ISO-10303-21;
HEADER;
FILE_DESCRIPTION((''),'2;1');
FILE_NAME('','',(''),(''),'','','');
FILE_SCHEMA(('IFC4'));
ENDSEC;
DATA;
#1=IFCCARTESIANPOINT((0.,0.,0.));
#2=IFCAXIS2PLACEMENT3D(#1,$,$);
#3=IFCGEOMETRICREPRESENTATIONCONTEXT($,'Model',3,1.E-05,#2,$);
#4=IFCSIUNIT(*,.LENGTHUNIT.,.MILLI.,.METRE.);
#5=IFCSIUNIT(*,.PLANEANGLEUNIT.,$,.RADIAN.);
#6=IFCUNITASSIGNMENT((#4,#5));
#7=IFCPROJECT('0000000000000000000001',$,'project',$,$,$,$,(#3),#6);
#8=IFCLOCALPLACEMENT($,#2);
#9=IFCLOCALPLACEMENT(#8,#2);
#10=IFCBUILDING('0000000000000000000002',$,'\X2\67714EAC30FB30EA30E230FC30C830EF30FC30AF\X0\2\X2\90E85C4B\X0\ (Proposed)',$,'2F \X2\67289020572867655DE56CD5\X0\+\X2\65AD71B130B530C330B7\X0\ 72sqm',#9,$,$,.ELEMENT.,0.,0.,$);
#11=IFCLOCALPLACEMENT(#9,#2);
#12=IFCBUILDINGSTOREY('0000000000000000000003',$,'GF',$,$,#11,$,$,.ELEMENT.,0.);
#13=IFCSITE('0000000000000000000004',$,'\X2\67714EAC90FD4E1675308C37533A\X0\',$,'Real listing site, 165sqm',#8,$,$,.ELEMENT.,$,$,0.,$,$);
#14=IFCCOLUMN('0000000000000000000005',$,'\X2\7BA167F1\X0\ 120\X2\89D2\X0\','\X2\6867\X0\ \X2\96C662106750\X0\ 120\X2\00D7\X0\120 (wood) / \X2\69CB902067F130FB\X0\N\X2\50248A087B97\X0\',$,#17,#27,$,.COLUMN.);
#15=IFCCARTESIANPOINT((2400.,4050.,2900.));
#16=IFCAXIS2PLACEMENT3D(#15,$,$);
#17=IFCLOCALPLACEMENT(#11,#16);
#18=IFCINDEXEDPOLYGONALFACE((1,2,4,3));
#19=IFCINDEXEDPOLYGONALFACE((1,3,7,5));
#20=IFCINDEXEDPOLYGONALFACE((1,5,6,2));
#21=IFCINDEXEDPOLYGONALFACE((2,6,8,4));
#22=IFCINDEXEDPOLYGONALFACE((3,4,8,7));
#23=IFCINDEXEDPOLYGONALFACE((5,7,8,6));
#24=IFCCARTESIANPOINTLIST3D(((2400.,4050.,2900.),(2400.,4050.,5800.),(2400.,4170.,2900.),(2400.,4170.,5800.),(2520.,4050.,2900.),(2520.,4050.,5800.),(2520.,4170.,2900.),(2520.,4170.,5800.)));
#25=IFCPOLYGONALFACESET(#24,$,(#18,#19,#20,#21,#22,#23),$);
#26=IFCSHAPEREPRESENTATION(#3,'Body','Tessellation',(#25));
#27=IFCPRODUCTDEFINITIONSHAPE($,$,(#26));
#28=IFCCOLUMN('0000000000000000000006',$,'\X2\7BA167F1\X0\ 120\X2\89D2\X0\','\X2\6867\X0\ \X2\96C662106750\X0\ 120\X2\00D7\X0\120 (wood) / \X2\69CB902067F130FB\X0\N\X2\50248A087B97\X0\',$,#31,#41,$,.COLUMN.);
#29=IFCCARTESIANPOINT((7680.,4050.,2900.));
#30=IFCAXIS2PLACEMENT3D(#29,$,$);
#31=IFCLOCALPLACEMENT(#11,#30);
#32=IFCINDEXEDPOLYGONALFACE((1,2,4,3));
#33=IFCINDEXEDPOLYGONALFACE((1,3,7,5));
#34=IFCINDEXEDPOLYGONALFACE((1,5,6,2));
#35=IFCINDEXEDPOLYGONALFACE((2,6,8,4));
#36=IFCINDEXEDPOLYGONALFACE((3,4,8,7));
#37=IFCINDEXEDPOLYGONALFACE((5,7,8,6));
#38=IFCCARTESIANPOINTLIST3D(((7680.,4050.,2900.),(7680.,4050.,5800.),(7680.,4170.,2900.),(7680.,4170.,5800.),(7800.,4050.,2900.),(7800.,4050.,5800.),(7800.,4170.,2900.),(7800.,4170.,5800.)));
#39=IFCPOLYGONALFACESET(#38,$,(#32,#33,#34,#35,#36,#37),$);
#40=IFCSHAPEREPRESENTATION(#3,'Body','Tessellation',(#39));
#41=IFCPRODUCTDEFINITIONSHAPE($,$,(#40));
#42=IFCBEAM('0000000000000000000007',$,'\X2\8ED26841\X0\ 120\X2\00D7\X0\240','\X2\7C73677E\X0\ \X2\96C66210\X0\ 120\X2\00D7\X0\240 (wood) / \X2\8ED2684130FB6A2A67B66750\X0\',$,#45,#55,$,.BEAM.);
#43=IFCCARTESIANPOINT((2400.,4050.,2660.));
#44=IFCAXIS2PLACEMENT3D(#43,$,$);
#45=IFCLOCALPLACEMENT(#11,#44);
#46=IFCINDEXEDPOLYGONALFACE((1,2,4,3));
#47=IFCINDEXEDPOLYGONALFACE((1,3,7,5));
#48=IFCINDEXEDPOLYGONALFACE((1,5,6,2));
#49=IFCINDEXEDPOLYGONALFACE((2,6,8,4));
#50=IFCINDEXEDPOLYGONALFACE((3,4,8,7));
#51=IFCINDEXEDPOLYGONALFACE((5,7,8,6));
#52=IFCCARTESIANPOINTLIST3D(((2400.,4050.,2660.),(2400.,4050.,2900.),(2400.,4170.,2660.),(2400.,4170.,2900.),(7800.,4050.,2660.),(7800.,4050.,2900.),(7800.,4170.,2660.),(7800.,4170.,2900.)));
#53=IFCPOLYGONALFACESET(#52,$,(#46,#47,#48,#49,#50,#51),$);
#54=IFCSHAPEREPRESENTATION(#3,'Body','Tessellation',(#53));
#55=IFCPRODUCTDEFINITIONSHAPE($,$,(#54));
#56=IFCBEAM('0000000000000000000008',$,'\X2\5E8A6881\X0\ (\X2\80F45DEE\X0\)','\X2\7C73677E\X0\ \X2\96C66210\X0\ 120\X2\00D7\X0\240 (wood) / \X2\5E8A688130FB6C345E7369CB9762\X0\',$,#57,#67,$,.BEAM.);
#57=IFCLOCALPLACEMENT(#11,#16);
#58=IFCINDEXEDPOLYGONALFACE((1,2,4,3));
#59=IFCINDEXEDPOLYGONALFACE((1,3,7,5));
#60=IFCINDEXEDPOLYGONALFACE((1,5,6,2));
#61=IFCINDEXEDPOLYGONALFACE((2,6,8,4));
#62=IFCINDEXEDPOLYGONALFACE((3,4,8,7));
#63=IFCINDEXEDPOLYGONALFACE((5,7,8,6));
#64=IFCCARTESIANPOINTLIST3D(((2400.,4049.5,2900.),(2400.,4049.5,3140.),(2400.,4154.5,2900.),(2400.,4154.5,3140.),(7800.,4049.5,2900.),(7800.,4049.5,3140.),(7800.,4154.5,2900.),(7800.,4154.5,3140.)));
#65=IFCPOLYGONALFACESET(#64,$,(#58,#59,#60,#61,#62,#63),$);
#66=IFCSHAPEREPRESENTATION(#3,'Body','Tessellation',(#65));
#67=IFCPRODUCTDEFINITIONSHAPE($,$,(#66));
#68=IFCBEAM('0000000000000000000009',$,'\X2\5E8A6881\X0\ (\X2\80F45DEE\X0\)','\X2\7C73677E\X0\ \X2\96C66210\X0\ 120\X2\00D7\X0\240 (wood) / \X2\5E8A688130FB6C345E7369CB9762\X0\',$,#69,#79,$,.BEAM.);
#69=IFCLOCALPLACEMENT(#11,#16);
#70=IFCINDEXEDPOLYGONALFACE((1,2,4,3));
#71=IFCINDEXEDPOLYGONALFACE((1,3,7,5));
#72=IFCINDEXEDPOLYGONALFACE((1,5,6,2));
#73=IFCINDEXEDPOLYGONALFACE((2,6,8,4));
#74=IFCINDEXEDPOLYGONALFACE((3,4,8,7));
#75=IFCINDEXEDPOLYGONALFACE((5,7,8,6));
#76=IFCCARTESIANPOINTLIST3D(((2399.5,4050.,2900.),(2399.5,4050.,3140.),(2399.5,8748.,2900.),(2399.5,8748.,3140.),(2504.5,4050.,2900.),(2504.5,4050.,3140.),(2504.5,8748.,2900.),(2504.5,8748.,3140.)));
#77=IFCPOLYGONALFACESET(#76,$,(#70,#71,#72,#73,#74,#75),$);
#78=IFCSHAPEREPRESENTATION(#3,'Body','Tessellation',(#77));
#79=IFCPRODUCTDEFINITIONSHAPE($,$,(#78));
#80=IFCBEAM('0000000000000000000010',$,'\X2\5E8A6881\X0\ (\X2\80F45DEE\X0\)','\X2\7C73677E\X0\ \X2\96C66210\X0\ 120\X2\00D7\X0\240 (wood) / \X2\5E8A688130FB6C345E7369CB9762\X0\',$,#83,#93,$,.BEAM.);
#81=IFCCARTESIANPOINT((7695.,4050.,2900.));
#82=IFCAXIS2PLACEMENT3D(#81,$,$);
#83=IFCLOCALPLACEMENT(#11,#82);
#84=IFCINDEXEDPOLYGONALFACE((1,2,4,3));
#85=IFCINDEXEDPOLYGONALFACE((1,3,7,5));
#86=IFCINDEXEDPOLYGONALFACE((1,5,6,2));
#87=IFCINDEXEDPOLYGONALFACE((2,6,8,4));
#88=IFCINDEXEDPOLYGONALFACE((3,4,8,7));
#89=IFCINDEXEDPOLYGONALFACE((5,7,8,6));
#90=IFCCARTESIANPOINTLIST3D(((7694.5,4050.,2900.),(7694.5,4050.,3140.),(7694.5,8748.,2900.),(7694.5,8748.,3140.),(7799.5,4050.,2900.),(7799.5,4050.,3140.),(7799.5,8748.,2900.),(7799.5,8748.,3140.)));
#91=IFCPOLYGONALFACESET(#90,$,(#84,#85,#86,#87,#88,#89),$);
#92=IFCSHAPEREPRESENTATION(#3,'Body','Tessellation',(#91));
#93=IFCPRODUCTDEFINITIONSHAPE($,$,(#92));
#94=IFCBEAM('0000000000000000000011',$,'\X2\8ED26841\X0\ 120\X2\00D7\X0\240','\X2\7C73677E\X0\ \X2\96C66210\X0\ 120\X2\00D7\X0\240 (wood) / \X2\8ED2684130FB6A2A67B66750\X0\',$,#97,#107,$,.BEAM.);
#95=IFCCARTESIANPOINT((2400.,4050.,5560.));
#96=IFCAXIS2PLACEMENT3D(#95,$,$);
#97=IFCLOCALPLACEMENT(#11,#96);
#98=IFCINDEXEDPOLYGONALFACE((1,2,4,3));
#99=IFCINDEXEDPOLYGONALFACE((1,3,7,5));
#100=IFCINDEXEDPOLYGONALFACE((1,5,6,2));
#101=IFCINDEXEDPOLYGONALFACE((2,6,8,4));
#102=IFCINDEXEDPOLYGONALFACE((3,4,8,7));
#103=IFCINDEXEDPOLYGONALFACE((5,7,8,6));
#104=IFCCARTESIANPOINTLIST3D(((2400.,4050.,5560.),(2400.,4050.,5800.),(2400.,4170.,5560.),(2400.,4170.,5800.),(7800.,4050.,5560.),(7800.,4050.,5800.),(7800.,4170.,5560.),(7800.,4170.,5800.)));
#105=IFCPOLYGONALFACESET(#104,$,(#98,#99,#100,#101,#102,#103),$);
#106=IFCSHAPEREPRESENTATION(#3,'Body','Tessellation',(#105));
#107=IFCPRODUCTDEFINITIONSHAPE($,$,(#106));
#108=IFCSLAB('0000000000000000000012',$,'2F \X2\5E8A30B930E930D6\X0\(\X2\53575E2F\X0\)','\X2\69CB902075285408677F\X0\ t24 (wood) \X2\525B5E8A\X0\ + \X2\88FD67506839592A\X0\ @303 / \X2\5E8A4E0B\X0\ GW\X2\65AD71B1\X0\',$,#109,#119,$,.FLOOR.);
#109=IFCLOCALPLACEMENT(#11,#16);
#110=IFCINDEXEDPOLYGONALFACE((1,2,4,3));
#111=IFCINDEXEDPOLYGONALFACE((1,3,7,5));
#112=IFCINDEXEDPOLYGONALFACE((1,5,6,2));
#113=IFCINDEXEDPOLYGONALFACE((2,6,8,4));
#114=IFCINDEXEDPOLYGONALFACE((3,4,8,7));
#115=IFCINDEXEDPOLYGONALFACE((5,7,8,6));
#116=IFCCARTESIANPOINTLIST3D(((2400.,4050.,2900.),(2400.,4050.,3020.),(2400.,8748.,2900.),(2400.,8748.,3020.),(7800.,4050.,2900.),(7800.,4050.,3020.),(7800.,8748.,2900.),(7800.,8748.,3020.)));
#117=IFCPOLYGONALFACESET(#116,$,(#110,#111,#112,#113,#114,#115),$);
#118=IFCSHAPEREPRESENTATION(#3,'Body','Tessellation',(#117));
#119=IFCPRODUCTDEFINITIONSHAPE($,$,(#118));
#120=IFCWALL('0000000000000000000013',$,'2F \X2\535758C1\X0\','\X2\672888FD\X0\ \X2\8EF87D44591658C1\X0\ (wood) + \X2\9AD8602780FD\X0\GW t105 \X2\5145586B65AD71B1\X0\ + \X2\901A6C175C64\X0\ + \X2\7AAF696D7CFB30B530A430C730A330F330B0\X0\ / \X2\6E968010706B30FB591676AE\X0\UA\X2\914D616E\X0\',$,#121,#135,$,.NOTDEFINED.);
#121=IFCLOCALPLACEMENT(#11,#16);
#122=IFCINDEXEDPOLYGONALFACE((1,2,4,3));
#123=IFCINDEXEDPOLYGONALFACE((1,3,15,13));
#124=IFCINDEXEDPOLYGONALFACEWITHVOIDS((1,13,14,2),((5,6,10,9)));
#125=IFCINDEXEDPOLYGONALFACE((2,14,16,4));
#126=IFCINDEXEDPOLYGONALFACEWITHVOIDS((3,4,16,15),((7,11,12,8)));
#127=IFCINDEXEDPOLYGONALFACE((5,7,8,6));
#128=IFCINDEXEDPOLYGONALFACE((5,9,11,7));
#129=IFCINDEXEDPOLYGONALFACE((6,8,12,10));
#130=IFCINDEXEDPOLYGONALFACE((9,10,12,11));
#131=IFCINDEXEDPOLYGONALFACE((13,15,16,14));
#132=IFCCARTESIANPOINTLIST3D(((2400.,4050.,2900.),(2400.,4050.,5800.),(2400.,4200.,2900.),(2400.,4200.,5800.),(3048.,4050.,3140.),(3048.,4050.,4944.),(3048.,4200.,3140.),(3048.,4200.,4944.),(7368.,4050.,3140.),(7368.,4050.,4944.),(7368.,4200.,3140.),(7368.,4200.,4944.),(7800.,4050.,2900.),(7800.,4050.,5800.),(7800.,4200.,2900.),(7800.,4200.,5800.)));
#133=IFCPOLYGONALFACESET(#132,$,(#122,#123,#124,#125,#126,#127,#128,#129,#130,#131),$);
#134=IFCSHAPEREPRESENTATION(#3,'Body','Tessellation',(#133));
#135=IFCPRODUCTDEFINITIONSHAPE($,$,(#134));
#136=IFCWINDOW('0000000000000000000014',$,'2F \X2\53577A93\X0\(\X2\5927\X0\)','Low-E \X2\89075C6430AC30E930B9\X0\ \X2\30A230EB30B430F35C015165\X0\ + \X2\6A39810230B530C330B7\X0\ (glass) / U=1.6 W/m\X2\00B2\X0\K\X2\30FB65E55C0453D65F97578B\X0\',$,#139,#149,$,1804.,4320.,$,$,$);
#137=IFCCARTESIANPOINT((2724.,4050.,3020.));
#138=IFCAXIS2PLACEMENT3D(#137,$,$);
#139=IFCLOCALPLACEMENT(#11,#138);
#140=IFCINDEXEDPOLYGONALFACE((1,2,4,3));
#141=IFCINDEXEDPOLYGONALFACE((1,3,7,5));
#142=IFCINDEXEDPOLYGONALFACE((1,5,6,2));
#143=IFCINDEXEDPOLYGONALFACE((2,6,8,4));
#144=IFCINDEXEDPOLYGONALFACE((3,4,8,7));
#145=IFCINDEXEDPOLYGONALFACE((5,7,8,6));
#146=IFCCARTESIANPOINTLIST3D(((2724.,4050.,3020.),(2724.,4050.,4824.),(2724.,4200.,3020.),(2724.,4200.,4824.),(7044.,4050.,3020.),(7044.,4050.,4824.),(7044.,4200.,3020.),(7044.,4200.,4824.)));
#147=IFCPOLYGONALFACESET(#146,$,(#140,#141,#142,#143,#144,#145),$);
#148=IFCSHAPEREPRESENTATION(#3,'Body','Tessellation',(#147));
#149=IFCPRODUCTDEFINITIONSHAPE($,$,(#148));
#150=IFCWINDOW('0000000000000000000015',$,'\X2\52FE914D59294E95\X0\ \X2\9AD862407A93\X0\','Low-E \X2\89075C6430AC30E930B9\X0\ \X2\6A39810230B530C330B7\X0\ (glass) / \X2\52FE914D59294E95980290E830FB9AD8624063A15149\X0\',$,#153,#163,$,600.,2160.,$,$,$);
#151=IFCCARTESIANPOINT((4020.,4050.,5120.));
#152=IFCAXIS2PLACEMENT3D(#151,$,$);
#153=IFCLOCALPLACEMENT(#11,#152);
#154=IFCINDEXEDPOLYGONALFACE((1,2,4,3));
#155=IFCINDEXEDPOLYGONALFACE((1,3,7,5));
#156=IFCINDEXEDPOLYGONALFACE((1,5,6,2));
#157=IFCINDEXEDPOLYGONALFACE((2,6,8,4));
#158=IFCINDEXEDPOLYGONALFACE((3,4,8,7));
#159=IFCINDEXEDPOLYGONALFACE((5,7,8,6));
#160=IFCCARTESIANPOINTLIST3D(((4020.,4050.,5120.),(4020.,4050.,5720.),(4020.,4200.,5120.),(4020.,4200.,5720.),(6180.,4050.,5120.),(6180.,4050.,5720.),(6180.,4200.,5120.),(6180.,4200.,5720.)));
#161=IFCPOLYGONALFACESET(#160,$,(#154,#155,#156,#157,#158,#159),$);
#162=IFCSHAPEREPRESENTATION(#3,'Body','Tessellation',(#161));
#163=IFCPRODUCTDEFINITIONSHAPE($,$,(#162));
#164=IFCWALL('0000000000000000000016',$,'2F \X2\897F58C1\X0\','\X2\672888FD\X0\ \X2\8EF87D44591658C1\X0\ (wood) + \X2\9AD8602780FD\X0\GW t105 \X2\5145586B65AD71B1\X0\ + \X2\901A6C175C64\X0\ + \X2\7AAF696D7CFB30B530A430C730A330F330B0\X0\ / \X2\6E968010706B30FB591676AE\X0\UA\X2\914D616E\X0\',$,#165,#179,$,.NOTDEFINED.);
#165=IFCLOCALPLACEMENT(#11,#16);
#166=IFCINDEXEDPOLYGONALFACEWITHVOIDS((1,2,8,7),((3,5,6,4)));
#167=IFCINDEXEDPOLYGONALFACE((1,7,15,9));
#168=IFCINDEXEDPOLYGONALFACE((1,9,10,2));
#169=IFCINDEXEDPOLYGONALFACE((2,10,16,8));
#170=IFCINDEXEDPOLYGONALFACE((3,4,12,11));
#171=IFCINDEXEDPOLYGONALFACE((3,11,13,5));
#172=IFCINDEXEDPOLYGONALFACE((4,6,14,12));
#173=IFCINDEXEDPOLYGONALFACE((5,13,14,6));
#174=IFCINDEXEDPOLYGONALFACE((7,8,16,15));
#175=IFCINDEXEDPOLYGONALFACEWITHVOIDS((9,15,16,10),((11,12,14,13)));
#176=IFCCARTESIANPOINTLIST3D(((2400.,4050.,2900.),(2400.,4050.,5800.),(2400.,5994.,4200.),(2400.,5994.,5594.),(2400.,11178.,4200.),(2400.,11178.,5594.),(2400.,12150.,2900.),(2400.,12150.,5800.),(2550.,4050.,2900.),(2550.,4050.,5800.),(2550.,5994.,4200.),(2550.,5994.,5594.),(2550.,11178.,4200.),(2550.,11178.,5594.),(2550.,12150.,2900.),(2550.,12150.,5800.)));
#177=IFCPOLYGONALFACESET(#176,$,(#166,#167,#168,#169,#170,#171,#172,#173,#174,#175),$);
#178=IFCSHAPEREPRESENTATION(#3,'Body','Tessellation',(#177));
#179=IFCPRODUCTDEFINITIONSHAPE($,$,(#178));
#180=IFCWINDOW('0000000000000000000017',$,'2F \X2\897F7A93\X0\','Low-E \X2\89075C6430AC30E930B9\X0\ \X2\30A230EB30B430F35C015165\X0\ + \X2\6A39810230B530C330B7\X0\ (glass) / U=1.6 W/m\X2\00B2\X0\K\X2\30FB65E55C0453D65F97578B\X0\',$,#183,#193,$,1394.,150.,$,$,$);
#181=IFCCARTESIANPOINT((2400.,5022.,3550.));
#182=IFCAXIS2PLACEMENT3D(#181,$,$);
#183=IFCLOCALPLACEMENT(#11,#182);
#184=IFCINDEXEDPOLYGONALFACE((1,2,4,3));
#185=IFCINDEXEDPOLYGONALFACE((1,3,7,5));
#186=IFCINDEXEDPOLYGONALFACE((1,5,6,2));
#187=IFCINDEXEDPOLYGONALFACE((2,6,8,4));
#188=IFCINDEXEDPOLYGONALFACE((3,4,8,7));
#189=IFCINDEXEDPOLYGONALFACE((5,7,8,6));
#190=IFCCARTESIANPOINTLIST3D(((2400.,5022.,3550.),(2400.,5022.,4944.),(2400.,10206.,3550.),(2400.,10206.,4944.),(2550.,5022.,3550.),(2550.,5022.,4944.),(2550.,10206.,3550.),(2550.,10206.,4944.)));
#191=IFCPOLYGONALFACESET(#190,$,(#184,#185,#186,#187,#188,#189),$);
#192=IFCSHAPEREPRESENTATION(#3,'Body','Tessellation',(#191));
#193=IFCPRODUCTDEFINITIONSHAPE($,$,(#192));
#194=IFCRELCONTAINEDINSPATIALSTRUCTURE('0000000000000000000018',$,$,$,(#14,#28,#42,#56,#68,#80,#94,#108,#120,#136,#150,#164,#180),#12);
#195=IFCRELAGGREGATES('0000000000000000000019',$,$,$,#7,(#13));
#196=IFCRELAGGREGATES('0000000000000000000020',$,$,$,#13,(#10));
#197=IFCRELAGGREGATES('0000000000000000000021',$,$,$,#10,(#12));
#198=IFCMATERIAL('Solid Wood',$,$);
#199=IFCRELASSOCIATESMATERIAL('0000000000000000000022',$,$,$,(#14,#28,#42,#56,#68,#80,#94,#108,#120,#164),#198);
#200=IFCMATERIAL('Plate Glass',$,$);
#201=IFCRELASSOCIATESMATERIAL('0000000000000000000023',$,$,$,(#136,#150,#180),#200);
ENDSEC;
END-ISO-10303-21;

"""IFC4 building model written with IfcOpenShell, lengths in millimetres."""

from ifc_helpers import new_model, si_unit, frame, frame_2d, origin, place, context, project, spatial, rectangle, extrude, material, element, fill, save


model = new_model("IFC4")

# Units and contexts
model_context = context("Model", 3, precision=1e-05, world=origin())
ifc_project = project(units=[si_unit("LENGTHUNIT", "METRE", prefix="MILLI"), si_unit("PLANEANGLEUNIT", "RADIAN")], contexts=[model_context])

# Site, building, storey
site_placement = place(None, origin())
site = spatial("IfcSite", under=ifc_project, at=site_placement, Name="東京都世田谷区", ObjectType="Real listing site, 165sqm", CompositionType="ELEMENT", RefElevation=0.0)
building_placement = place(site_placement, origin())
building = spatial("IfcBuilding", under=site, at=building_placement, Name="東京・リモートワーク2部屋 (Proposed)", ObjectType="2F 木造在来工法+断熱サッシ 72sqm", CompositionType="ELEMENT", ElevationOfRefHeight=0.0, ElevationOfTerrain=0.0)
storey_placement = place(building_placement, origin())
storey = spatial("IfcBuildingStorey", under=building, at=storey_placement, Name="GF", CompositionType="ELEMENT", Elevation=0.0)

# Columns
ifc_material_1 = material(Name="Solid Wood")
column_1_placement = place(storey_placement, frame((2400.0, 4050.0, 2900.0)))
element("IfcColumn", 1, at=column_1_placement, inside=storey, material=ifc_material_1, Name="管柱 120角", Description="桧 集成材 120×120 (wood) / 構造柱・N値計算", PredefinedType="COLUMN", context=model_context, shape_type="SweptSolid", body=[
    extrude(rectangle(XDim=120.0, YDim=120.0, at=frame_2d((60.0, 60.0))), frame((2400.0, 4050.0, 2900.0)), (0.0, 0.0, 1.0), 2900.0),
])
column_2_placement = place(storey_placement, frame((7680.0, 4050.0, 2900.0)))
element("IfcColumn", 2, at=column_2_placement, inside=storey, material=ifc_material_1, Name="管柱 120角", Description="桧 集成材 120×120 (wood) / 構造柱・N値計算", PredefinedType="COLUMN", context=model_context, shape_type="SweptSolid", body=[
    extrude(rectangle(XDim=120.0, YDim=120.0, at=frame_2d((60.0, 60.0))), frame((7680.0, 4050.0, 2900.0)), (0.0, 0.0, 1.0), 2900.0),
])

# Beams
beam_1_placement = place(storey_placement, frame((2400.0, 4050.0, 2660.0)))
element("IfcBeam", 3, at=beam_1_placement, inside=storey, material=ifc_material_1, Name="軒桁 120×240", Description="米松 集成 120×240 (wood) / 軒桁・横架材", PredefinedType="BEAM", context=model_context, shape_type="SweptSolid", body=[
    extrude(rectangle(XDim=5400.0, YDim=120.0, at=frame_2d((2700.0, 60.0))), frame((2400.0, 4050.0, 2660.0)), (0.0, 0.0, 1.0), 240.0),
])
beam_2_placement = place(storey_placement, frame((2400.0, 4050.0, 2900.0)))
element("IfcBeam", 4, at=beam_2_placement, inside=storey, material=ifc_material_1, Name="床梁 (胴差)", Description="米松 集成 120×240 (wood) / 床梁・水平構面", PredefinedType="BEAM", context=model_context, shape_type="SweptSolid", body=[
    extrude(rectangle(XDim=5400.0, YDim=105.0, at=frame_2d((2700.0, 52.0))), frame((2400.0, 4050.0, 2900.0)), (0.0, 0.0, 1.0), 240.0),
])
beam_3_placement = place(storey_placement, frame((2400.0, 4050.0, 2900.0)))
element("IfcBeam", 5, at=beam_3_placement, inside=storey, material=ifc_material_1, Name="床梁 (胴差)", Description="米松 集成 120×240 (wood) / 床梁・水平構面", PredefinedType="BEAM", context=model_context, shape_type="SweptSolid", body=[
    extrude(rectangle(XDim=105.0, YDim=4698.0, at=frame_2d((52.0, 2349.0))), frame((2400.0, 4050.0, 2900.0)), (0.0, 0.0, 1.0), 240.0),
])
beam_4_placement = place(storey_placement, frame((7695.0, 4050.0, 2900.0)))
element("IfcBeam", 6, at=beam_4_placement, inside=storey, material=ifc_material_1, Name="床梁 (胴差)", Description="米松 集成 120×240 (wood) / 床梁・水平構面", PredefinedType="BEAM", context=model_context, shape_type="SweptSolid", body=[
    extrude(rectangle(XDim=105.0, YDim=4698.0, at=frame_2d((52.0, 2349.0))), frame((7695.0, 4050.0, 2900.0)), (0.0, 0.0, 1.0), 240.0),
])
beam_5_placement = place(storey_placement, frame((2400.0, 4050.0, 5560.0)))
element("IfcBeam", 7, at=beam_5_placement, inside=storey, material=ifc_material_1, Name="軒桁 120×240", Description="米松 集成 120×240 (wood) / 軒桁・横架材", PredefinedType="BEAM", context=model_context, shape_type="SweptSolid", body=[
    extrude(rectangle(XDim=5400.0, YDim=120.0, at=frame_2d((2700.0, 60.0))), frame((2400.0, 4050.0, 5560.0)), (0.0, 0.0, 1.0), 240.0),
])

# Slab
slab_placement = place(storey_placement, frame((2400.0, 4050.0, 2900.0)))
element("IfcSlab", 8, at=slab_placement, inside=storey, material=ifc_material_1, Name="2F 床スラブ(南帯)", Description="構造用合板 t24 (wood) 剛床 + 製材根太 @303 / 床下 GW断熱", PredefinedType="FLOOR", context=model_context, shape_type="SweptSolid", body=[
    extrude(rectangle(XDim=5400.0, YDim=4698.0, at=frame_2d((2700.0, 2349.0))), frame((2400.0, 4050.0, 2900.0)), (0.0, 0.0, 1.0), 120.0),
])

# Wall, openings, windows
wall_1_placement = place(storey_placement, frame((2400.0, 4050.0, 2900.0)))
wall_1 = element("IfcWall", 9, at=wall_1_placement, inside=storey, material=ifc_material_1, Name="2F 南壁", Description="木製 軸組外壁 (wood) + 高性能GW t105 充填断熱 + 通気層 + 窯業系サイディング / 準耐火・外皮UA配慮", PredefinedType="NOTDEFINED", context=model_context, shape_type="SweptSolid", body=[
    extrude(rectangle(XDim=5400.0, YDim=150.0, at=frame_2d((2700.0, 75.0))), frame((2400.0, 4050.0, 2900.0)), (0.0, 0.0, 1.0), 2900.0),
])
opening_1_placement = place(storey_placement, frame((2724.0, 4050.0, 3020.0)))
opening_1 = element("IfcOpeningElement", 10, at=opening_1_placement, cuts=wall_1, PredefinedType="NOTDEFINED", context=model_context, shape_type="SweptSolid", body=[
    extrude(rectangle(XDim=4320.0, YDim=150.0, at=frame_2d((2160.0, 75.0))), frame((2724.0, 4050.0, 3020.0)), (0.0, 0.0, 1.0), 1804.0),
])
opening_2_placement = place(storey_placement, frame((4020.0, 4050.0, 5120.0)))
opening_2 = element("IfcOpeningElement", 11, at=opening_2_placement, cuts=wall_1, PredefinedType="NOTDEFINED", context=model_context, shape_type="SweptSolid", body=[
    extrude(rectangle(XDim=2160.0, YDim=150.0, at=frame_2d((1080.0, 75.0))), frame((4020.0, 4050.0, 5120.0)), (0.0, 0.0, 1.0), 600.0),
])
ifc_material_2 = material(Name="Plate Glass")
window_1_placement = place(storey_placement, frame((2724.0, 4050.0, 3020.0)))
window_1 = element("IfcWindow", 12, at=window_1_placement, inside=storey, material=ifc_material_2, Name="2F 南窓(大)", Description="Low-E 複層ガラス アルゴン封入 + 樹脂サッシ (glass) / U=1.6 W/m²K・日射取得型", OverallHeight=1804.0, OverallWidth=4320.0, context=model_context, shape_type="SweptSolid", body=[
    extrude(rectangle(XDim=4320.0, YDim=150.0, at=frame_2d((2160.0, 75.0))), frame((2724.0, 4050.0, 3020.0)), (0.0, 0.0, 1.0), 1804.0),
])
fill(opening_1, window_1)
window_2_placement = place(storey_placement, frame((4020.0, 4050.0, 5120.0)))
window_2 = element("IfcWindow", 13, at=window_2_placement, inside=storey, material=ifc_material_2, Name="勾配天井 高所窓", Description="Low-E 複層ガラス 樹脂サッシ (glass) / 勾配天井頂部・高所採光", OverallHeight=600.0, OverallWidth=2160.0, context=model_context, shape_type="SweptSolid", body=[
    extrude(rectangle(XDim=2160.0, YDim=150.0, at=frame_2d((1080.0, 75.0))), frame((4020.0, 4050.0, 5120.0)), (0.0, 0.0, 1.0), 600.0),
])
fill(opening_2, window_2)

# Wall, opening, window
wall_2_placement = place(storey_placement, frame((2400.0, 4050.0, 2900.0)))
wall_2 = element("IfcWall", 14, at=wall_2_placement, inside=storey, material=ifc_material_1, Name="2F 西壁", Description="木製 軸組外壁 (wood) + 高性能GW t105 充填断熱 + 通気層 + 窯業系サイディング / 準耐火・外皮UA配慮", PredefinedType="NOTDEFINED", context=model_context, shape_type="SweptSolid", body=[
    extrude(rectangle(XDim=150.0, YDim=8100.0, at=frame_2d((75.0, 4050.0))), frame((2400.0, 4050.0, 2900.0)), (0.0, 0.0, 1.0), 2900.0),
])
opening_3_placement = place(storey_placement, frame((2400.0, 5022.0, 3550.0)))
opening_3 = element("IfcOpeningElement", 15, at=opening_3_placement, cuts=wall_2, PredefinedType="NOTDEFINED", context=model_context, shape_type="SweptSolid", body=[
    extrude(rectangle(XDim=150.0, YDim=5184.0, at=frame_2d((75.0, 2592.0))), frame((2400.0, 5022.0, 3550.0)), (0.0, 0.0, 1.0), 1394.0),
])
window_3_placement = place(storey_placement, frame((2400.0, 5022.0, 3550.0)))
window_3 = element("IfcWindow", 16, at=window_3_placement, inside=storey, material=ifc_material_2, Name="2F 西窓", Description="Low-E 複層ガラス アルゴン封入 + 樹脂サッシ (glass) / U=1.6 W/m²K・日射取得型", OverallHeight=1394.0, OverallWidth=150.0, context=model_context, shape_type="SweptSolid", body=[
    extrude(rectangle(XDim=150.0, YDim=5184.0, at=frame_2d((75.0, 2592.0))), frame((2400.0, 5022.0, 3550.0)), (0.0, 0.0, 1.0), 1394.0),
])
fill(opening_3, window_3)

save(model, "model.ifc")
